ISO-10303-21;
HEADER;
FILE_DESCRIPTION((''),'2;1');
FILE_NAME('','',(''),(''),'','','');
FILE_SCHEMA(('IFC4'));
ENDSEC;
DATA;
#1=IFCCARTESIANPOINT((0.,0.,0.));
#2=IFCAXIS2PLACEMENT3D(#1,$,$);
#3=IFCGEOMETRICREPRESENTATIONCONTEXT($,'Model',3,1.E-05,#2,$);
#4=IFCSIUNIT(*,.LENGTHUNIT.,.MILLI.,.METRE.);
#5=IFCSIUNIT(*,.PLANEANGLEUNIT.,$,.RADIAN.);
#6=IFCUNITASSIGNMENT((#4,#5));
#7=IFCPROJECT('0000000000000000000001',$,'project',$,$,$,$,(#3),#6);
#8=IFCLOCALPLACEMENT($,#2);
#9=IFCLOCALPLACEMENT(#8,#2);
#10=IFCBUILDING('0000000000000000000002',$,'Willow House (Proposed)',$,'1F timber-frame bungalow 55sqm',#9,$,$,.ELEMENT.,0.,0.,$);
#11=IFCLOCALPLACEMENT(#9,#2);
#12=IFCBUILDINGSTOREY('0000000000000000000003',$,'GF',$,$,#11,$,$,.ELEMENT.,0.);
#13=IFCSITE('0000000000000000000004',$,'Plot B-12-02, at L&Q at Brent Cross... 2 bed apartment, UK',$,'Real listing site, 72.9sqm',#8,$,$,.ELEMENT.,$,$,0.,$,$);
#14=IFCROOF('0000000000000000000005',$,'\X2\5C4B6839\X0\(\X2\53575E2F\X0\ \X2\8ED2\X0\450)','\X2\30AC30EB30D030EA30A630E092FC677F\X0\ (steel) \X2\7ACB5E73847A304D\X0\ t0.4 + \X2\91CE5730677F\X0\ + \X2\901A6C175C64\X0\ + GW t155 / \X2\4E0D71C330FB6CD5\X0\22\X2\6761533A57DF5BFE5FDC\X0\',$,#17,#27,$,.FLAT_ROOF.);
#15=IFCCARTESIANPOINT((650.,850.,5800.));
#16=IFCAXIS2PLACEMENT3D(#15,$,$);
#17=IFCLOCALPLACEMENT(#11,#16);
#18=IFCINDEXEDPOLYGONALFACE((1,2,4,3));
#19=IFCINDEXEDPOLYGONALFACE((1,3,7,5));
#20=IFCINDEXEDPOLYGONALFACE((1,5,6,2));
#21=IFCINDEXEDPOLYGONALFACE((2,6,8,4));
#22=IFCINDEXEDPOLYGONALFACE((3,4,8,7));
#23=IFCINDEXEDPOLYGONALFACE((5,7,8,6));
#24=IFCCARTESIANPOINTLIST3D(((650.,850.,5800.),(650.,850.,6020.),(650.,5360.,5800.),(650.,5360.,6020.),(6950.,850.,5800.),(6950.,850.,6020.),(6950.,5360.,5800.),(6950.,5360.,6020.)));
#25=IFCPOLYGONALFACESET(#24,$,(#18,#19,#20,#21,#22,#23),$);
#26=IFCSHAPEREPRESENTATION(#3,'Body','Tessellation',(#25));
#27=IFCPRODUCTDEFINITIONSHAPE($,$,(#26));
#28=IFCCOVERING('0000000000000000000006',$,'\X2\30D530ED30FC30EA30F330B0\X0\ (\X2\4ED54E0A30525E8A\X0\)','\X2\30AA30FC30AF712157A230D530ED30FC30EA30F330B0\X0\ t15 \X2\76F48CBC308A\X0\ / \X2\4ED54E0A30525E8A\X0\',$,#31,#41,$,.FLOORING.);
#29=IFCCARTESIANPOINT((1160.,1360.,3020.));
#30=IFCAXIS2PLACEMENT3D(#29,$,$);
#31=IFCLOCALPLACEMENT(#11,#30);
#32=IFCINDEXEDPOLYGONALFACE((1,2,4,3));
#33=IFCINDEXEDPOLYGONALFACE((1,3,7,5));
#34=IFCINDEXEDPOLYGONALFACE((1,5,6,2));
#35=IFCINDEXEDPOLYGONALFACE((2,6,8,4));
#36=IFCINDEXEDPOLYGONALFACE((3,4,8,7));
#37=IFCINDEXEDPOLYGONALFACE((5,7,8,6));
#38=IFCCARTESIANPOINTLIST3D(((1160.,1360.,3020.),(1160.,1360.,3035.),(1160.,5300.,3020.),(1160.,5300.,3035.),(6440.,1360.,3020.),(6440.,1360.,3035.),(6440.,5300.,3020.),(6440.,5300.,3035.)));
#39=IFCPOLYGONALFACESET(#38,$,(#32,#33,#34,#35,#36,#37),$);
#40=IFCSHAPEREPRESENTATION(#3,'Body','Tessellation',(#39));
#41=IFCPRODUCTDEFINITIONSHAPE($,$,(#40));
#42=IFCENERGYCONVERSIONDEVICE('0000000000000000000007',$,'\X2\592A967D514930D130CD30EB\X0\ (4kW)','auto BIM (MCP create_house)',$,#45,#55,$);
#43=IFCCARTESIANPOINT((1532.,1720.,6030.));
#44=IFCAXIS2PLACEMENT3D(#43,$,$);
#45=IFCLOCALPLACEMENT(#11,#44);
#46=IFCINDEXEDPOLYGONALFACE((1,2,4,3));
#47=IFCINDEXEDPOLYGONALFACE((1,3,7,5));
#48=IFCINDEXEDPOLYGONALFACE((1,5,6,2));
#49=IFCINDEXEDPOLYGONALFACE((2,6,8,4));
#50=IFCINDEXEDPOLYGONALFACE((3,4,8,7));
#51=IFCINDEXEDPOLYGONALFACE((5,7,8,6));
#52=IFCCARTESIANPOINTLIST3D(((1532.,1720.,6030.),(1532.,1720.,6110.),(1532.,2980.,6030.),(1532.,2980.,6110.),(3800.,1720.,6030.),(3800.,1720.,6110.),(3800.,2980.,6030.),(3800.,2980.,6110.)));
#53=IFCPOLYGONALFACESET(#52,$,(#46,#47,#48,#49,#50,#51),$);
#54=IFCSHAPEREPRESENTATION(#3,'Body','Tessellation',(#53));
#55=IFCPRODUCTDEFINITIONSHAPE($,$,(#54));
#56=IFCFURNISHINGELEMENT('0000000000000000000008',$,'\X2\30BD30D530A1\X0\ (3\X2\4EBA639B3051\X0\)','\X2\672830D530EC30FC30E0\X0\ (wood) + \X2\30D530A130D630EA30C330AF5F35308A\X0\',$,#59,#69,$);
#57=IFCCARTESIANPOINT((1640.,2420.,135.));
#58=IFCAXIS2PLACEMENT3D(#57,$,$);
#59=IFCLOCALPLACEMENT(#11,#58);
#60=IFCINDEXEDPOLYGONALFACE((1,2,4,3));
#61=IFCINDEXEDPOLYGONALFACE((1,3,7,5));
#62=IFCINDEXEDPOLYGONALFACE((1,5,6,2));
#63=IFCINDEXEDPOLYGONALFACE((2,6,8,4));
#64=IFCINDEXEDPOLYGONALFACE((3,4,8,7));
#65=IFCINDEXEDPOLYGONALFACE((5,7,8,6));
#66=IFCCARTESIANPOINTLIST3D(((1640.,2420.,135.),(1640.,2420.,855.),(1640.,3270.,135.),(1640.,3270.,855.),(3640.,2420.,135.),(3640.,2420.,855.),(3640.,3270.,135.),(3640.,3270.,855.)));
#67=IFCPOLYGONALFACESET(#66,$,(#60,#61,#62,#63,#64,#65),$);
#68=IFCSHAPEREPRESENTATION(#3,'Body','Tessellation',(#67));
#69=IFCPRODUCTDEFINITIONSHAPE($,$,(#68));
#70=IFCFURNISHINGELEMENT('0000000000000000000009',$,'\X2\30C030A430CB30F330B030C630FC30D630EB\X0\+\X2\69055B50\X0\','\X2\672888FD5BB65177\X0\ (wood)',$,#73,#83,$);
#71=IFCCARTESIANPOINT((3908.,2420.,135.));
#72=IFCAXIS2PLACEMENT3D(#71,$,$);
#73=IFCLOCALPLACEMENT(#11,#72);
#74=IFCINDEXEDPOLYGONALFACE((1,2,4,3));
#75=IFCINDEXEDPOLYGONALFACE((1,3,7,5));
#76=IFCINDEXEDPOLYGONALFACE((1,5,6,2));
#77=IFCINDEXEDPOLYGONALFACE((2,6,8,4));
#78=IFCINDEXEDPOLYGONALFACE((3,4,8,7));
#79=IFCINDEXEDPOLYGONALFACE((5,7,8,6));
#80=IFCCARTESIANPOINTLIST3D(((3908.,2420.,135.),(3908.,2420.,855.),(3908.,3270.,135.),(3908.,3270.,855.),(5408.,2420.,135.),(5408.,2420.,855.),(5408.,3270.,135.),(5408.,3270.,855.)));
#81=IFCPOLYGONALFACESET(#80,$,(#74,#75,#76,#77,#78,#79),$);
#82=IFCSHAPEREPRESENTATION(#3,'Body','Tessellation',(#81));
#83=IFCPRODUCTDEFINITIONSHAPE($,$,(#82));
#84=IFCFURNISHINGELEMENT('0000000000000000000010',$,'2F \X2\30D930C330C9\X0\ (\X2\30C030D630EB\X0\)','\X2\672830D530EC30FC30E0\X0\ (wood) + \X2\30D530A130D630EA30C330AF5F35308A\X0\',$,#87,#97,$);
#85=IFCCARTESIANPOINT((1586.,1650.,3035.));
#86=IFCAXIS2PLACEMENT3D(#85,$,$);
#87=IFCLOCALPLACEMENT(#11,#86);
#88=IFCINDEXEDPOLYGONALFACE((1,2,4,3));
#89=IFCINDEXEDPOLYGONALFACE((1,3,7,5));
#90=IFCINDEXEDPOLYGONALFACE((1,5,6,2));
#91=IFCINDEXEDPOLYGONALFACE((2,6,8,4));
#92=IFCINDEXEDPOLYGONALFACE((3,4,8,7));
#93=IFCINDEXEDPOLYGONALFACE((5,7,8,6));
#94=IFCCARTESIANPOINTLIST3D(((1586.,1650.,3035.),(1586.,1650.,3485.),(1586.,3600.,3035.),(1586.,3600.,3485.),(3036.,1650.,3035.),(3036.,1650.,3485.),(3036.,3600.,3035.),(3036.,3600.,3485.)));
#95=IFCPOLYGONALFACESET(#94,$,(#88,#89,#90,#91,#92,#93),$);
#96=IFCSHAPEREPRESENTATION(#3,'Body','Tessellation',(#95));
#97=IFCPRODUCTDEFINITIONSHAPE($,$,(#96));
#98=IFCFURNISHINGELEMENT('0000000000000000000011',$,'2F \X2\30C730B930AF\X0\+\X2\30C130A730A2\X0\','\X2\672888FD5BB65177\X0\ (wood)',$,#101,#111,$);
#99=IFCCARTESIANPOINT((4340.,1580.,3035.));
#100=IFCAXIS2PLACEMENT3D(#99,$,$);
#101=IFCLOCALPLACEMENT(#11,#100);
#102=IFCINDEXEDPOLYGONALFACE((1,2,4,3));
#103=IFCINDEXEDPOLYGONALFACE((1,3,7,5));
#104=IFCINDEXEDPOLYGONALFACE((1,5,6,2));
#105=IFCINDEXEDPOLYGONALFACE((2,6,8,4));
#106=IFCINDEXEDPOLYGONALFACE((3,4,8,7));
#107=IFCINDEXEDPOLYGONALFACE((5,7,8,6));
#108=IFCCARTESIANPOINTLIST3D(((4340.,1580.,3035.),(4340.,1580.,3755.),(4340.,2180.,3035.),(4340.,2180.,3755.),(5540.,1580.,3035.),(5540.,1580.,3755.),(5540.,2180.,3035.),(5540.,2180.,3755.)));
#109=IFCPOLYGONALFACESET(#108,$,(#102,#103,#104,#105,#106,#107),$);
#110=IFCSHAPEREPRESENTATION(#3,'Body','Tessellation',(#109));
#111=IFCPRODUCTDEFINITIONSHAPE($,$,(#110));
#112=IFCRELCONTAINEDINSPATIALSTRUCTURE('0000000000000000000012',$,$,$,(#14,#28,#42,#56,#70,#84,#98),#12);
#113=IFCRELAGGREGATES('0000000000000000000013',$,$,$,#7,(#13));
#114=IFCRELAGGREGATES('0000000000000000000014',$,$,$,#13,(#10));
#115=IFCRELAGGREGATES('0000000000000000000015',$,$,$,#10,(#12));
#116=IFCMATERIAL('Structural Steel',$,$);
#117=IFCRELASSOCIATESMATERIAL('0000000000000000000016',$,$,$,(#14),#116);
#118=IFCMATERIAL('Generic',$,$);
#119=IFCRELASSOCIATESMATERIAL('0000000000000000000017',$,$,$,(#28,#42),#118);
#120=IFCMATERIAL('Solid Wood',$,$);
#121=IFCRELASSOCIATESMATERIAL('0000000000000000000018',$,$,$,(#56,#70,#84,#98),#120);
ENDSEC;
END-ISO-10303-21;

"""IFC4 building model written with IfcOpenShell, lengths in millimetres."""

from ifc_helpers import new_model, si_unit, frame, frame_2d, origin, place, context, project, spatial, rectangle, extrude, material, element, save


model = new_model("IFC4")

# Units and contexts
model_context = context("Model", 3, precision=1e-05, world=origin())
ifc_project = project(units=[si_unit("LENGTHUNIT", "METRE", prefix="MILLI"), si_unit("PLANEANGLEUNIT", "RADIAN")], contexts=[model_context])

# Site, building, storey
site_placement = place(None, origin())
site = spatial("IfcSite", under=ifc_project, at=site_placement, Name="Plot B-12-02, at L&Q at Brent Cross... 2 bed apartment, UK", ObjectType="Real listing site, 72.9sqm", CompositionType="ELEMENT", RefElevation=0.0)
building_placement = place(site_placement, origin())
building = spatial("IfcBuilding", under=site, at=building_placement, Name="Willow House (Proposed)", ObjectType="1F timber-frame bungalow 55sqm", CompositionType="ELEMENT", ElevationOfRefHeight=0.0, ElevationOfTerrain=0.0)
storey_placement = place(building_placement, origin())
storey = spatial("IfcBuildingStorey", under=building, at=storey_placement, Name="GF", CompositionType="ELEMENT", Elevation=0.0)

# Shared definitions
ifc_material_1 = material(Name="Solid Wood")

# Shared definitions
ifc_material_2 = material(Name="Generic")

# Roof
ifc_material_3 = material(Name="Structural Steel")
for number, where, name in (
    (1, (650.0, 850.0, 5800.0), "屋根(南帯 軒450)"),
):
    element("IfcRoof", number, at=place(storey_placement, frame(where)), inside=storey, material=ifc_material_3, Name=name, Description="ガルバリウム鋼板 (steel) 立平葺き t0.4 + 野地板 + 通気層 + GW t155 / 不燃・法22条区域対応", PredefinedType="FLAT_ROOF", context=model_context, shape_type="SweptSolid", body=[
        extrude(rectangle(XDim=6300.0, YDim=4510.0, at=frame_2d((3150.0, 2255.0))), frame((650.0, 850.0, 5800.0)), (0.0, 0.0, 1.0), 220.0),
    ])

# Covering
covering_placement = place(storey_placement, frame((1160.0, 1360.0, 3020.0)))
element("IfcCovering", 2, at=covering_placement, inside=storey, material=ifc_material_2, Name="フローリング (仕上げ床)", Description="オーク無垢フローリング t15 直貼り / 仕上げ床", PredefinedType="FLOORING", context=model_context, shape_type="SweptSolid", body=[
    extrude(rectangle(XDim=5280.0, YDim=3940.0, at=frame_2d((2640.0, 1970.0))), frame((1160.0, 1360.0, 3020.0)), (0.0, 0.0, 1.0), 15.0),
])

# Energy conversion device
energy_conversion_device_placement = place(storey_placement, frame((1532.0, 1720.0, 6030.0)))
element("IfcEnergyConversionDevice", 3, at=energy_conversion_device_placement, inside=storey, material=ifc_material_2, Name="太陽光パネル (4kW)", Description="auto BIM (MCP create_house)", context=model_context, shape_type="SweptSolid", body=[
    extrude(rectangle(XDim=2268.0, YDim=1260.0, at=frame_2d((1134.0, 630.0))), frame((1532.0, 1720.0, 6030.0)), (0.0, 0.0, 1.0), 80.0),
])

# Furnishing elements
furnishing_1_placement = place(storey_placement, frame((1640.0, 2420.0, 135.0)))
element("IfcFurnishingElement", 4, at=furnishing_1_placement, inside=storey, material=ifc_material_1, Name="ソファ (3人掛け)", Description="木フレーム (wood) + ファブリック張り", context=model_context, shape_type="SweptSolid", body=[
    extrude(rectangle(XDim=2000.0, YDim=850.0, at=frame_2d((1000.0, 425.0))), frame((1640.0, 2420.0, 135.0)), (0.0, 0.0, 1.0), 720.0),
])
furnishing_2_placement = place(storey_placement, frame((3908.0, 2420.0, 135.0)))
element("IfcFurnishingElement", 5, at=furnishing_2_placement, inside=storey, material=ifc_material_1, Name="ダイニングテーブル+椅子", Description="木製家具 (wood)", context=model_context, shape_type="SweptSolid", body=[
    extrude(rectangle(XDim=1500.0, YDim=850.0, at=frame_2d((750.0, 425.0))), frame((3908.0, 2420.0, 135.0)), (0.0, 0.0, 1.0), 720.0),
])
furnishing_3_placement = place(storey_placement, frame((1586.0, 1650.0, 3035.0)))
element("IfcFurnishingElement", 6, at=furnishing_3_placement, inside=storey, material=ifc_material_1, Name="2F ベッド (ダブル)", Description="木フレーム (wood) + ファブリック張り", context=model_context, shape_type="SweptSolid", body=[
    extrude(rectangle(XDim=1450.0, YDim=1950.0, at=frame_2d((725.0, 975.0))), frame((1586.0, 1650.0, 3035.0)), (0.0, 0.0, 1.0), 450.0),
])
furnishing_4_placement = place(storey_placement, frame((4340.0, 1580.0, 3035.0)))
element("IfcFurnishingElement", 7, at=furnishing_4_placement, inside=storey, material=ifc_material_1, Name="2F デスク+チェア", Description="木製家具 (wood)", context=model_context, shape_type="SweptSolid", body=[
    extrude(rectangle(XDim=1200.0, YDim=600.0, at=frame_2d((600.0, 300.0))), frame((4340.0, 1580.0, 3035.0)), (0.0, 0.0, 1.0), 720.0),
])

save(model, "model.ifc")
